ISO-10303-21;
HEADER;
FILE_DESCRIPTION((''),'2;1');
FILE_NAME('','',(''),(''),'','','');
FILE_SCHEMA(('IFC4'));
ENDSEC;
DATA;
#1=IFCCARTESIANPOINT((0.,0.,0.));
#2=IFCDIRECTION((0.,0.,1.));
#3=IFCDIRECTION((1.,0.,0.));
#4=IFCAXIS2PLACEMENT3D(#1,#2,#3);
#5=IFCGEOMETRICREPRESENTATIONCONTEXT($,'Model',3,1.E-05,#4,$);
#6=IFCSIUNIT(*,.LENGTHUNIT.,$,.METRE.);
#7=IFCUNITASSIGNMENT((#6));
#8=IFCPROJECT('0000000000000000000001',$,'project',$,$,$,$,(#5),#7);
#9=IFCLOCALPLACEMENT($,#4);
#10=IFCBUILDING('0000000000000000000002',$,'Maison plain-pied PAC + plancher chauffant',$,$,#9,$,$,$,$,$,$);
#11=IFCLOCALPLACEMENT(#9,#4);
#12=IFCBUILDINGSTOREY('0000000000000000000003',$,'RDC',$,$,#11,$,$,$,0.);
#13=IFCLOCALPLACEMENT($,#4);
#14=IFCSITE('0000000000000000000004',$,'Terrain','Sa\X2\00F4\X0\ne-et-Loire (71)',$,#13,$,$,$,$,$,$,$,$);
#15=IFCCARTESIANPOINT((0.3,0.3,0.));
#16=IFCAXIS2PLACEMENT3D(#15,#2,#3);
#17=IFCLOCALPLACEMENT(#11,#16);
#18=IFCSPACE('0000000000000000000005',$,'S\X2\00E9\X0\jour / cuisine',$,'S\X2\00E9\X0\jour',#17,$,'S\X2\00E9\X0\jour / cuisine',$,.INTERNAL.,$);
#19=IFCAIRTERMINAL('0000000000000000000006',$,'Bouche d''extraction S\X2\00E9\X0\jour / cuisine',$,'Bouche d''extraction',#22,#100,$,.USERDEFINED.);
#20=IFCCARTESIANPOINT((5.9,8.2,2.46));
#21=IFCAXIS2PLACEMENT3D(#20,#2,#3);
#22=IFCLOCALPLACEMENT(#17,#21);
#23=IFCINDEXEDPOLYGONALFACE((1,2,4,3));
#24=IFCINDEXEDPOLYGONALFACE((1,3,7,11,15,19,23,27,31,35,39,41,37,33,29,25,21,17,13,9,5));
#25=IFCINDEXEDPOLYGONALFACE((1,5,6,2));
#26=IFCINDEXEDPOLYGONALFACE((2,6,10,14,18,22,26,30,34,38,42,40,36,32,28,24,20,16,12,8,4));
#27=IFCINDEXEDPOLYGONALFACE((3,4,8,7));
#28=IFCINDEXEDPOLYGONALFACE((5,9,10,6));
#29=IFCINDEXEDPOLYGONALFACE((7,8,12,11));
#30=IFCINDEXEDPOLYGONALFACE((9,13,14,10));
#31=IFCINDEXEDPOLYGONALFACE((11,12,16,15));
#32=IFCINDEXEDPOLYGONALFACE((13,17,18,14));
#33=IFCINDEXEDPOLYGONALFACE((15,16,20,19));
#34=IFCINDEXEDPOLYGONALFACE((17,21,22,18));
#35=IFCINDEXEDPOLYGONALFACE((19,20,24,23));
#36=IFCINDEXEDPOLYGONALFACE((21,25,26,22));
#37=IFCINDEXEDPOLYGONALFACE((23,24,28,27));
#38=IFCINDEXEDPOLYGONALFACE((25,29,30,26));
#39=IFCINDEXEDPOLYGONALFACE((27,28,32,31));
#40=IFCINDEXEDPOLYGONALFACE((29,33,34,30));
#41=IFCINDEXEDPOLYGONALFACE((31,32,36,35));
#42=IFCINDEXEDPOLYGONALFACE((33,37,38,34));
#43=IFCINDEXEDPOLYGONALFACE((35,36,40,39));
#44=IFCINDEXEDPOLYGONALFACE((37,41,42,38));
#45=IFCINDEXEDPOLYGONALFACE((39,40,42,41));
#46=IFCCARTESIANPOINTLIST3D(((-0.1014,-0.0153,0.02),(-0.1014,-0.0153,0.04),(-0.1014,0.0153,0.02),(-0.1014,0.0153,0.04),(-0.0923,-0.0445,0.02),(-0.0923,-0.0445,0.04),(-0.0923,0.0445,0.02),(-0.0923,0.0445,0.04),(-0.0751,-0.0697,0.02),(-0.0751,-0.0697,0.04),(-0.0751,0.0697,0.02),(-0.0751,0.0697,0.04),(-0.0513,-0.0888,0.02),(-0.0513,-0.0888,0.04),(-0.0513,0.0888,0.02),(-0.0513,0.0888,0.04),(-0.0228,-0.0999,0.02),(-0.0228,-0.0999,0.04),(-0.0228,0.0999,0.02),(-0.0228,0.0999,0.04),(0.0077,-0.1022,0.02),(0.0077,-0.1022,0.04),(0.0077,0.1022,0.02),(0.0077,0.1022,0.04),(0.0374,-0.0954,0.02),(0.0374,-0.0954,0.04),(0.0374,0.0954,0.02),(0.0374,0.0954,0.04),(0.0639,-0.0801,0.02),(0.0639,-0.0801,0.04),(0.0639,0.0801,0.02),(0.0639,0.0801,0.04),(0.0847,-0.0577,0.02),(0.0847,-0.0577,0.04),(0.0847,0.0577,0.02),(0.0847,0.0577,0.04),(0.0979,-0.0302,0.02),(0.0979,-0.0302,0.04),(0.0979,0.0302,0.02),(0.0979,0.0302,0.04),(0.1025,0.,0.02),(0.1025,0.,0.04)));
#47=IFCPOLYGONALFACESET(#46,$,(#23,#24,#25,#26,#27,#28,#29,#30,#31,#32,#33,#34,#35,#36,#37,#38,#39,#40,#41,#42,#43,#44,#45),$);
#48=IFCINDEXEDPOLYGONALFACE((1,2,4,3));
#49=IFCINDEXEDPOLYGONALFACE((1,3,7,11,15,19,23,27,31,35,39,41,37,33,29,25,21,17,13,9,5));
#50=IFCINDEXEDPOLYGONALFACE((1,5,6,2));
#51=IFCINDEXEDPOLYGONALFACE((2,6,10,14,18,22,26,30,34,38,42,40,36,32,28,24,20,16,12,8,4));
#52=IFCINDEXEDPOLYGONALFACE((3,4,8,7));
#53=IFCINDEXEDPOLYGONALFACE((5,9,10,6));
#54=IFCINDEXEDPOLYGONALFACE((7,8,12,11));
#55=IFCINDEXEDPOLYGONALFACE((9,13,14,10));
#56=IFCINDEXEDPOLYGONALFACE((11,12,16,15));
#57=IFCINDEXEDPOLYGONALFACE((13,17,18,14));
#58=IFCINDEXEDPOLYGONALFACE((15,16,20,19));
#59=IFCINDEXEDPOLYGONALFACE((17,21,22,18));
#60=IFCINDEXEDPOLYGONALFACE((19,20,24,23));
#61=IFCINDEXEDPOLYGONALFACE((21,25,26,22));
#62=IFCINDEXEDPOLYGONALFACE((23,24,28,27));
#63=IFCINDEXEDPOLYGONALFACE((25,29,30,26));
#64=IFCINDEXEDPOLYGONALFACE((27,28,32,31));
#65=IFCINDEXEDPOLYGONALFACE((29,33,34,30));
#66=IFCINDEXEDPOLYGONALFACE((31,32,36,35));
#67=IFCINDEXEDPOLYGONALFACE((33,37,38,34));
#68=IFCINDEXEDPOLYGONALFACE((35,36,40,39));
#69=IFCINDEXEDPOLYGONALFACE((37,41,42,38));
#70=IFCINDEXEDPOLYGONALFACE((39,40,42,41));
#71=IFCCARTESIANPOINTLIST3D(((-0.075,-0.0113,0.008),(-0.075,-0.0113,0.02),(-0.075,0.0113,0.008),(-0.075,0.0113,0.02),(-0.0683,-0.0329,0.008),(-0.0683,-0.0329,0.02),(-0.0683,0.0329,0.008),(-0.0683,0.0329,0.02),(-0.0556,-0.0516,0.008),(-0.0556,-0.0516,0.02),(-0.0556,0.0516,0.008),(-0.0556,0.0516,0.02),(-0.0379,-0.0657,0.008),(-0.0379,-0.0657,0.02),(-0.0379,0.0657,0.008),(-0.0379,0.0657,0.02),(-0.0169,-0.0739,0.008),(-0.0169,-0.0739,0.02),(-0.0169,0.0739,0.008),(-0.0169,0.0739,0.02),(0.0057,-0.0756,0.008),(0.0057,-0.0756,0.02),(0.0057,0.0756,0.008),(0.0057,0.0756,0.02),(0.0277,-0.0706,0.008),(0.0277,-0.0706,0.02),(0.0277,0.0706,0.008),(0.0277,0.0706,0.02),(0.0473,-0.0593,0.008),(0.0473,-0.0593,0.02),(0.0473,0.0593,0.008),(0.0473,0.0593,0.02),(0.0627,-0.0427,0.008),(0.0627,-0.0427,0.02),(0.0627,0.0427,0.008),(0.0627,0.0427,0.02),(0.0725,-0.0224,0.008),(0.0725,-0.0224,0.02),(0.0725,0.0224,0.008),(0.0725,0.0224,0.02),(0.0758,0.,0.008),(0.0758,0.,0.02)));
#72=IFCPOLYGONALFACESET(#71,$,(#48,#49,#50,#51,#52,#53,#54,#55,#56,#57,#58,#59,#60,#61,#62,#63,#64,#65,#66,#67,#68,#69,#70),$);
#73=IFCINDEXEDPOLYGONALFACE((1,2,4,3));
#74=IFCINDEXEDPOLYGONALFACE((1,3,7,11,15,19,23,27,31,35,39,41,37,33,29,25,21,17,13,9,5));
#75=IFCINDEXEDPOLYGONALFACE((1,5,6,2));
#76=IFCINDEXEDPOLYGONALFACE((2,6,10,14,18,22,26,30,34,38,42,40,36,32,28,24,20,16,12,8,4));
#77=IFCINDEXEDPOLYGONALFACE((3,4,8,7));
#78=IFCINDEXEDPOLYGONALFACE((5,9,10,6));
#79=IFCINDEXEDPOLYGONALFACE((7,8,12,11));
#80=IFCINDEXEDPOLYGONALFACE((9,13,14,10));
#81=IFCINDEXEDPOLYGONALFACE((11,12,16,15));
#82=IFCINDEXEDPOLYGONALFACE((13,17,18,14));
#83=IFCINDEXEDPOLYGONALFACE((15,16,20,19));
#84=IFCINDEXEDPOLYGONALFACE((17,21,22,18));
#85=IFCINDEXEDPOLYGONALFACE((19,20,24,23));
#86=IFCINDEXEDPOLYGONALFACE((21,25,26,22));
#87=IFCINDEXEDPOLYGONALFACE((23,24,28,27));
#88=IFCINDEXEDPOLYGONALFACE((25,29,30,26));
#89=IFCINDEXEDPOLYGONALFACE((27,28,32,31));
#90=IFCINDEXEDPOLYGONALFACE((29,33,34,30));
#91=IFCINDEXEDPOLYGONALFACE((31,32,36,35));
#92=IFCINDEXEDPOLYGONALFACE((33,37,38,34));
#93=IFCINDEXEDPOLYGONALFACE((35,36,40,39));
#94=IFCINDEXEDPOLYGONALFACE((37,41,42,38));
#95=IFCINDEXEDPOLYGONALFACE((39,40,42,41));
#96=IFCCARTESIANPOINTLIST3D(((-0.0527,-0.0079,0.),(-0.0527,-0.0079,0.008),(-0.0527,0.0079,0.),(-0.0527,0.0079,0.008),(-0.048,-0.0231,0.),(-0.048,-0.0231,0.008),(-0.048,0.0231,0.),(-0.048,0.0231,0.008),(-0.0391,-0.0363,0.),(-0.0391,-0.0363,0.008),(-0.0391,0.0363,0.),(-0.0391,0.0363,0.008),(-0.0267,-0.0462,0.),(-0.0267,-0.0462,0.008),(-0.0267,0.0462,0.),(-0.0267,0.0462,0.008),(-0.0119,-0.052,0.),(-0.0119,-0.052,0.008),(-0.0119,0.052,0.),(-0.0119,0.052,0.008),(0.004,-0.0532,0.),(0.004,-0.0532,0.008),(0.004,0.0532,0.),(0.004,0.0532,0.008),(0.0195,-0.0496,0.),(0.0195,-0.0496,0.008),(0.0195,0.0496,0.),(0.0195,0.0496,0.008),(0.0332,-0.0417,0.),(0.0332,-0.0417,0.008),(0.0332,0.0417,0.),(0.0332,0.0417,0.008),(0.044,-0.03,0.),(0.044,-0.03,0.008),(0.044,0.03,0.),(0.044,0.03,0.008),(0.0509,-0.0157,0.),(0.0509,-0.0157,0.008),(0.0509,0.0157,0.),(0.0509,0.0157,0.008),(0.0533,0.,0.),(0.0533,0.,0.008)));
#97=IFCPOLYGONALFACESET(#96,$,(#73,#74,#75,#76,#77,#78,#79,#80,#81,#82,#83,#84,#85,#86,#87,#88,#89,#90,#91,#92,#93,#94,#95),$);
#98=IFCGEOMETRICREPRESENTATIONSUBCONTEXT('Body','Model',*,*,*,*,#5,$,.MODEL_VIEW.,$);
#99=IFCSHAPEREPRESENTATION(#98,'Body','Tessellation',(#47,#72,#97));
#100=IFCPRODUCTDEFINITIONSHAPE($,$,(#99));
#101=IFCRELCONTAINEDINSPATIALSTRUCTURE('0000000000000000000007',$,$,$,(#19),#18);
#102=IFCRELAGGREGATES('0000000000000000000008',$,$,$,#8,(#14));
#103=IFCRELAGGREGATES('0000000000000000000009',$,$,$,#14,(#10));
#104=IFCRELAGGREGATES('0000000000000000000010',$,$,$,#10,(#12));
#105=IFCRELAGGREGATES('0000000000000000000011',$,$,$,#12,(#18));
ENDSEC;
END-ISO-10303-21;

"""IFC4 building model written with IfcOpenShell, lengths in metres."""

from ifc_helpers import new_model, si_unit, frame, origin_with_axes, place, context, subcontext, project, spatial, circle, extrude, element, save


model = new_model("IFC4")

# Units and contexts
model_context = context("Model", 3, precision=1e-05, world=origin_with_axes())
body_context = subcontext(model_context, "Body", "Model", "MODEL_VIEW")
ifc_project = project(units=[si_unit("LENGTHUNIT", "METRE")], contexts=[model_context])

# Site, building, storey
site_placement = place(None, origin_with_axes())
site = spatial("IfcSite", under=ifc_project, at=site_placement, Name="Terrain", Description="Saône-et-Loire (71)")
building_placement = place(None, origin_with_axes())
building = spatial("IfcBuilding", under=site, at=building_placement, Name="Maison plain-pied PAC + plancher chauffant")
storey_placement = place(building_placement, origin_with_axes())
storey = spatial("IfcBuildingStorey", under=building, at=storey_placement, Name="RDC", Elevation=0.0)

# Shared definitions
space_placement = place(storey_placement, frame((0.3, 0.3, 0.0), z_axis=(0.0, 0.0, 1.0), x_axis=(1.0, 0.0, 0.0)))
space = spatial("IfcSpace", under=storey, at=space_placement, Name="Séjour / cuisine", ObjectType="Séjour", LongName="Séjour / cuisine", PredefinedType="INTERNAL")

# Air terminal
air_terminal_placement = place(space_placement, frame((5.9, 8.2, 2.46), z_axis=(0.0, 0.0, 1.0), x_axis=(1.0, 0.0, 0.0)))
element("IfcAirTerminal", 1, at=air_terminal_placement, inside=space, Name="Bouche d'extraction Séjour / cuisine", ObjectType="Bouche d'extraction", PredefinedType="USERDEFINED", context=body_context, shape_type="SweptSolid", body=[
    extrude(circle(Radius=0.1025), frame((0.0, 0.0, 0.02), z_axis=(0.0, 0.0, 1.0), x_axis=(1.0, 0.0, 0.0)), (0.0, 0.0, 1.0), 0.02),
    extrude(circle(Radius=0.0759), frame((0.0, 0.0, 0.008), z_axis=(0.0, 0.0, 1.0), x_axis=(1.0, 0.0, 0.0)), (0.0, 0.0, 1.0), 0.012),
    extrude(circle(Radius=0.0533), origin_with_axes(), (0.0, 0.0, 1.0), 0.008),
])

save(model, "model.ifc")
